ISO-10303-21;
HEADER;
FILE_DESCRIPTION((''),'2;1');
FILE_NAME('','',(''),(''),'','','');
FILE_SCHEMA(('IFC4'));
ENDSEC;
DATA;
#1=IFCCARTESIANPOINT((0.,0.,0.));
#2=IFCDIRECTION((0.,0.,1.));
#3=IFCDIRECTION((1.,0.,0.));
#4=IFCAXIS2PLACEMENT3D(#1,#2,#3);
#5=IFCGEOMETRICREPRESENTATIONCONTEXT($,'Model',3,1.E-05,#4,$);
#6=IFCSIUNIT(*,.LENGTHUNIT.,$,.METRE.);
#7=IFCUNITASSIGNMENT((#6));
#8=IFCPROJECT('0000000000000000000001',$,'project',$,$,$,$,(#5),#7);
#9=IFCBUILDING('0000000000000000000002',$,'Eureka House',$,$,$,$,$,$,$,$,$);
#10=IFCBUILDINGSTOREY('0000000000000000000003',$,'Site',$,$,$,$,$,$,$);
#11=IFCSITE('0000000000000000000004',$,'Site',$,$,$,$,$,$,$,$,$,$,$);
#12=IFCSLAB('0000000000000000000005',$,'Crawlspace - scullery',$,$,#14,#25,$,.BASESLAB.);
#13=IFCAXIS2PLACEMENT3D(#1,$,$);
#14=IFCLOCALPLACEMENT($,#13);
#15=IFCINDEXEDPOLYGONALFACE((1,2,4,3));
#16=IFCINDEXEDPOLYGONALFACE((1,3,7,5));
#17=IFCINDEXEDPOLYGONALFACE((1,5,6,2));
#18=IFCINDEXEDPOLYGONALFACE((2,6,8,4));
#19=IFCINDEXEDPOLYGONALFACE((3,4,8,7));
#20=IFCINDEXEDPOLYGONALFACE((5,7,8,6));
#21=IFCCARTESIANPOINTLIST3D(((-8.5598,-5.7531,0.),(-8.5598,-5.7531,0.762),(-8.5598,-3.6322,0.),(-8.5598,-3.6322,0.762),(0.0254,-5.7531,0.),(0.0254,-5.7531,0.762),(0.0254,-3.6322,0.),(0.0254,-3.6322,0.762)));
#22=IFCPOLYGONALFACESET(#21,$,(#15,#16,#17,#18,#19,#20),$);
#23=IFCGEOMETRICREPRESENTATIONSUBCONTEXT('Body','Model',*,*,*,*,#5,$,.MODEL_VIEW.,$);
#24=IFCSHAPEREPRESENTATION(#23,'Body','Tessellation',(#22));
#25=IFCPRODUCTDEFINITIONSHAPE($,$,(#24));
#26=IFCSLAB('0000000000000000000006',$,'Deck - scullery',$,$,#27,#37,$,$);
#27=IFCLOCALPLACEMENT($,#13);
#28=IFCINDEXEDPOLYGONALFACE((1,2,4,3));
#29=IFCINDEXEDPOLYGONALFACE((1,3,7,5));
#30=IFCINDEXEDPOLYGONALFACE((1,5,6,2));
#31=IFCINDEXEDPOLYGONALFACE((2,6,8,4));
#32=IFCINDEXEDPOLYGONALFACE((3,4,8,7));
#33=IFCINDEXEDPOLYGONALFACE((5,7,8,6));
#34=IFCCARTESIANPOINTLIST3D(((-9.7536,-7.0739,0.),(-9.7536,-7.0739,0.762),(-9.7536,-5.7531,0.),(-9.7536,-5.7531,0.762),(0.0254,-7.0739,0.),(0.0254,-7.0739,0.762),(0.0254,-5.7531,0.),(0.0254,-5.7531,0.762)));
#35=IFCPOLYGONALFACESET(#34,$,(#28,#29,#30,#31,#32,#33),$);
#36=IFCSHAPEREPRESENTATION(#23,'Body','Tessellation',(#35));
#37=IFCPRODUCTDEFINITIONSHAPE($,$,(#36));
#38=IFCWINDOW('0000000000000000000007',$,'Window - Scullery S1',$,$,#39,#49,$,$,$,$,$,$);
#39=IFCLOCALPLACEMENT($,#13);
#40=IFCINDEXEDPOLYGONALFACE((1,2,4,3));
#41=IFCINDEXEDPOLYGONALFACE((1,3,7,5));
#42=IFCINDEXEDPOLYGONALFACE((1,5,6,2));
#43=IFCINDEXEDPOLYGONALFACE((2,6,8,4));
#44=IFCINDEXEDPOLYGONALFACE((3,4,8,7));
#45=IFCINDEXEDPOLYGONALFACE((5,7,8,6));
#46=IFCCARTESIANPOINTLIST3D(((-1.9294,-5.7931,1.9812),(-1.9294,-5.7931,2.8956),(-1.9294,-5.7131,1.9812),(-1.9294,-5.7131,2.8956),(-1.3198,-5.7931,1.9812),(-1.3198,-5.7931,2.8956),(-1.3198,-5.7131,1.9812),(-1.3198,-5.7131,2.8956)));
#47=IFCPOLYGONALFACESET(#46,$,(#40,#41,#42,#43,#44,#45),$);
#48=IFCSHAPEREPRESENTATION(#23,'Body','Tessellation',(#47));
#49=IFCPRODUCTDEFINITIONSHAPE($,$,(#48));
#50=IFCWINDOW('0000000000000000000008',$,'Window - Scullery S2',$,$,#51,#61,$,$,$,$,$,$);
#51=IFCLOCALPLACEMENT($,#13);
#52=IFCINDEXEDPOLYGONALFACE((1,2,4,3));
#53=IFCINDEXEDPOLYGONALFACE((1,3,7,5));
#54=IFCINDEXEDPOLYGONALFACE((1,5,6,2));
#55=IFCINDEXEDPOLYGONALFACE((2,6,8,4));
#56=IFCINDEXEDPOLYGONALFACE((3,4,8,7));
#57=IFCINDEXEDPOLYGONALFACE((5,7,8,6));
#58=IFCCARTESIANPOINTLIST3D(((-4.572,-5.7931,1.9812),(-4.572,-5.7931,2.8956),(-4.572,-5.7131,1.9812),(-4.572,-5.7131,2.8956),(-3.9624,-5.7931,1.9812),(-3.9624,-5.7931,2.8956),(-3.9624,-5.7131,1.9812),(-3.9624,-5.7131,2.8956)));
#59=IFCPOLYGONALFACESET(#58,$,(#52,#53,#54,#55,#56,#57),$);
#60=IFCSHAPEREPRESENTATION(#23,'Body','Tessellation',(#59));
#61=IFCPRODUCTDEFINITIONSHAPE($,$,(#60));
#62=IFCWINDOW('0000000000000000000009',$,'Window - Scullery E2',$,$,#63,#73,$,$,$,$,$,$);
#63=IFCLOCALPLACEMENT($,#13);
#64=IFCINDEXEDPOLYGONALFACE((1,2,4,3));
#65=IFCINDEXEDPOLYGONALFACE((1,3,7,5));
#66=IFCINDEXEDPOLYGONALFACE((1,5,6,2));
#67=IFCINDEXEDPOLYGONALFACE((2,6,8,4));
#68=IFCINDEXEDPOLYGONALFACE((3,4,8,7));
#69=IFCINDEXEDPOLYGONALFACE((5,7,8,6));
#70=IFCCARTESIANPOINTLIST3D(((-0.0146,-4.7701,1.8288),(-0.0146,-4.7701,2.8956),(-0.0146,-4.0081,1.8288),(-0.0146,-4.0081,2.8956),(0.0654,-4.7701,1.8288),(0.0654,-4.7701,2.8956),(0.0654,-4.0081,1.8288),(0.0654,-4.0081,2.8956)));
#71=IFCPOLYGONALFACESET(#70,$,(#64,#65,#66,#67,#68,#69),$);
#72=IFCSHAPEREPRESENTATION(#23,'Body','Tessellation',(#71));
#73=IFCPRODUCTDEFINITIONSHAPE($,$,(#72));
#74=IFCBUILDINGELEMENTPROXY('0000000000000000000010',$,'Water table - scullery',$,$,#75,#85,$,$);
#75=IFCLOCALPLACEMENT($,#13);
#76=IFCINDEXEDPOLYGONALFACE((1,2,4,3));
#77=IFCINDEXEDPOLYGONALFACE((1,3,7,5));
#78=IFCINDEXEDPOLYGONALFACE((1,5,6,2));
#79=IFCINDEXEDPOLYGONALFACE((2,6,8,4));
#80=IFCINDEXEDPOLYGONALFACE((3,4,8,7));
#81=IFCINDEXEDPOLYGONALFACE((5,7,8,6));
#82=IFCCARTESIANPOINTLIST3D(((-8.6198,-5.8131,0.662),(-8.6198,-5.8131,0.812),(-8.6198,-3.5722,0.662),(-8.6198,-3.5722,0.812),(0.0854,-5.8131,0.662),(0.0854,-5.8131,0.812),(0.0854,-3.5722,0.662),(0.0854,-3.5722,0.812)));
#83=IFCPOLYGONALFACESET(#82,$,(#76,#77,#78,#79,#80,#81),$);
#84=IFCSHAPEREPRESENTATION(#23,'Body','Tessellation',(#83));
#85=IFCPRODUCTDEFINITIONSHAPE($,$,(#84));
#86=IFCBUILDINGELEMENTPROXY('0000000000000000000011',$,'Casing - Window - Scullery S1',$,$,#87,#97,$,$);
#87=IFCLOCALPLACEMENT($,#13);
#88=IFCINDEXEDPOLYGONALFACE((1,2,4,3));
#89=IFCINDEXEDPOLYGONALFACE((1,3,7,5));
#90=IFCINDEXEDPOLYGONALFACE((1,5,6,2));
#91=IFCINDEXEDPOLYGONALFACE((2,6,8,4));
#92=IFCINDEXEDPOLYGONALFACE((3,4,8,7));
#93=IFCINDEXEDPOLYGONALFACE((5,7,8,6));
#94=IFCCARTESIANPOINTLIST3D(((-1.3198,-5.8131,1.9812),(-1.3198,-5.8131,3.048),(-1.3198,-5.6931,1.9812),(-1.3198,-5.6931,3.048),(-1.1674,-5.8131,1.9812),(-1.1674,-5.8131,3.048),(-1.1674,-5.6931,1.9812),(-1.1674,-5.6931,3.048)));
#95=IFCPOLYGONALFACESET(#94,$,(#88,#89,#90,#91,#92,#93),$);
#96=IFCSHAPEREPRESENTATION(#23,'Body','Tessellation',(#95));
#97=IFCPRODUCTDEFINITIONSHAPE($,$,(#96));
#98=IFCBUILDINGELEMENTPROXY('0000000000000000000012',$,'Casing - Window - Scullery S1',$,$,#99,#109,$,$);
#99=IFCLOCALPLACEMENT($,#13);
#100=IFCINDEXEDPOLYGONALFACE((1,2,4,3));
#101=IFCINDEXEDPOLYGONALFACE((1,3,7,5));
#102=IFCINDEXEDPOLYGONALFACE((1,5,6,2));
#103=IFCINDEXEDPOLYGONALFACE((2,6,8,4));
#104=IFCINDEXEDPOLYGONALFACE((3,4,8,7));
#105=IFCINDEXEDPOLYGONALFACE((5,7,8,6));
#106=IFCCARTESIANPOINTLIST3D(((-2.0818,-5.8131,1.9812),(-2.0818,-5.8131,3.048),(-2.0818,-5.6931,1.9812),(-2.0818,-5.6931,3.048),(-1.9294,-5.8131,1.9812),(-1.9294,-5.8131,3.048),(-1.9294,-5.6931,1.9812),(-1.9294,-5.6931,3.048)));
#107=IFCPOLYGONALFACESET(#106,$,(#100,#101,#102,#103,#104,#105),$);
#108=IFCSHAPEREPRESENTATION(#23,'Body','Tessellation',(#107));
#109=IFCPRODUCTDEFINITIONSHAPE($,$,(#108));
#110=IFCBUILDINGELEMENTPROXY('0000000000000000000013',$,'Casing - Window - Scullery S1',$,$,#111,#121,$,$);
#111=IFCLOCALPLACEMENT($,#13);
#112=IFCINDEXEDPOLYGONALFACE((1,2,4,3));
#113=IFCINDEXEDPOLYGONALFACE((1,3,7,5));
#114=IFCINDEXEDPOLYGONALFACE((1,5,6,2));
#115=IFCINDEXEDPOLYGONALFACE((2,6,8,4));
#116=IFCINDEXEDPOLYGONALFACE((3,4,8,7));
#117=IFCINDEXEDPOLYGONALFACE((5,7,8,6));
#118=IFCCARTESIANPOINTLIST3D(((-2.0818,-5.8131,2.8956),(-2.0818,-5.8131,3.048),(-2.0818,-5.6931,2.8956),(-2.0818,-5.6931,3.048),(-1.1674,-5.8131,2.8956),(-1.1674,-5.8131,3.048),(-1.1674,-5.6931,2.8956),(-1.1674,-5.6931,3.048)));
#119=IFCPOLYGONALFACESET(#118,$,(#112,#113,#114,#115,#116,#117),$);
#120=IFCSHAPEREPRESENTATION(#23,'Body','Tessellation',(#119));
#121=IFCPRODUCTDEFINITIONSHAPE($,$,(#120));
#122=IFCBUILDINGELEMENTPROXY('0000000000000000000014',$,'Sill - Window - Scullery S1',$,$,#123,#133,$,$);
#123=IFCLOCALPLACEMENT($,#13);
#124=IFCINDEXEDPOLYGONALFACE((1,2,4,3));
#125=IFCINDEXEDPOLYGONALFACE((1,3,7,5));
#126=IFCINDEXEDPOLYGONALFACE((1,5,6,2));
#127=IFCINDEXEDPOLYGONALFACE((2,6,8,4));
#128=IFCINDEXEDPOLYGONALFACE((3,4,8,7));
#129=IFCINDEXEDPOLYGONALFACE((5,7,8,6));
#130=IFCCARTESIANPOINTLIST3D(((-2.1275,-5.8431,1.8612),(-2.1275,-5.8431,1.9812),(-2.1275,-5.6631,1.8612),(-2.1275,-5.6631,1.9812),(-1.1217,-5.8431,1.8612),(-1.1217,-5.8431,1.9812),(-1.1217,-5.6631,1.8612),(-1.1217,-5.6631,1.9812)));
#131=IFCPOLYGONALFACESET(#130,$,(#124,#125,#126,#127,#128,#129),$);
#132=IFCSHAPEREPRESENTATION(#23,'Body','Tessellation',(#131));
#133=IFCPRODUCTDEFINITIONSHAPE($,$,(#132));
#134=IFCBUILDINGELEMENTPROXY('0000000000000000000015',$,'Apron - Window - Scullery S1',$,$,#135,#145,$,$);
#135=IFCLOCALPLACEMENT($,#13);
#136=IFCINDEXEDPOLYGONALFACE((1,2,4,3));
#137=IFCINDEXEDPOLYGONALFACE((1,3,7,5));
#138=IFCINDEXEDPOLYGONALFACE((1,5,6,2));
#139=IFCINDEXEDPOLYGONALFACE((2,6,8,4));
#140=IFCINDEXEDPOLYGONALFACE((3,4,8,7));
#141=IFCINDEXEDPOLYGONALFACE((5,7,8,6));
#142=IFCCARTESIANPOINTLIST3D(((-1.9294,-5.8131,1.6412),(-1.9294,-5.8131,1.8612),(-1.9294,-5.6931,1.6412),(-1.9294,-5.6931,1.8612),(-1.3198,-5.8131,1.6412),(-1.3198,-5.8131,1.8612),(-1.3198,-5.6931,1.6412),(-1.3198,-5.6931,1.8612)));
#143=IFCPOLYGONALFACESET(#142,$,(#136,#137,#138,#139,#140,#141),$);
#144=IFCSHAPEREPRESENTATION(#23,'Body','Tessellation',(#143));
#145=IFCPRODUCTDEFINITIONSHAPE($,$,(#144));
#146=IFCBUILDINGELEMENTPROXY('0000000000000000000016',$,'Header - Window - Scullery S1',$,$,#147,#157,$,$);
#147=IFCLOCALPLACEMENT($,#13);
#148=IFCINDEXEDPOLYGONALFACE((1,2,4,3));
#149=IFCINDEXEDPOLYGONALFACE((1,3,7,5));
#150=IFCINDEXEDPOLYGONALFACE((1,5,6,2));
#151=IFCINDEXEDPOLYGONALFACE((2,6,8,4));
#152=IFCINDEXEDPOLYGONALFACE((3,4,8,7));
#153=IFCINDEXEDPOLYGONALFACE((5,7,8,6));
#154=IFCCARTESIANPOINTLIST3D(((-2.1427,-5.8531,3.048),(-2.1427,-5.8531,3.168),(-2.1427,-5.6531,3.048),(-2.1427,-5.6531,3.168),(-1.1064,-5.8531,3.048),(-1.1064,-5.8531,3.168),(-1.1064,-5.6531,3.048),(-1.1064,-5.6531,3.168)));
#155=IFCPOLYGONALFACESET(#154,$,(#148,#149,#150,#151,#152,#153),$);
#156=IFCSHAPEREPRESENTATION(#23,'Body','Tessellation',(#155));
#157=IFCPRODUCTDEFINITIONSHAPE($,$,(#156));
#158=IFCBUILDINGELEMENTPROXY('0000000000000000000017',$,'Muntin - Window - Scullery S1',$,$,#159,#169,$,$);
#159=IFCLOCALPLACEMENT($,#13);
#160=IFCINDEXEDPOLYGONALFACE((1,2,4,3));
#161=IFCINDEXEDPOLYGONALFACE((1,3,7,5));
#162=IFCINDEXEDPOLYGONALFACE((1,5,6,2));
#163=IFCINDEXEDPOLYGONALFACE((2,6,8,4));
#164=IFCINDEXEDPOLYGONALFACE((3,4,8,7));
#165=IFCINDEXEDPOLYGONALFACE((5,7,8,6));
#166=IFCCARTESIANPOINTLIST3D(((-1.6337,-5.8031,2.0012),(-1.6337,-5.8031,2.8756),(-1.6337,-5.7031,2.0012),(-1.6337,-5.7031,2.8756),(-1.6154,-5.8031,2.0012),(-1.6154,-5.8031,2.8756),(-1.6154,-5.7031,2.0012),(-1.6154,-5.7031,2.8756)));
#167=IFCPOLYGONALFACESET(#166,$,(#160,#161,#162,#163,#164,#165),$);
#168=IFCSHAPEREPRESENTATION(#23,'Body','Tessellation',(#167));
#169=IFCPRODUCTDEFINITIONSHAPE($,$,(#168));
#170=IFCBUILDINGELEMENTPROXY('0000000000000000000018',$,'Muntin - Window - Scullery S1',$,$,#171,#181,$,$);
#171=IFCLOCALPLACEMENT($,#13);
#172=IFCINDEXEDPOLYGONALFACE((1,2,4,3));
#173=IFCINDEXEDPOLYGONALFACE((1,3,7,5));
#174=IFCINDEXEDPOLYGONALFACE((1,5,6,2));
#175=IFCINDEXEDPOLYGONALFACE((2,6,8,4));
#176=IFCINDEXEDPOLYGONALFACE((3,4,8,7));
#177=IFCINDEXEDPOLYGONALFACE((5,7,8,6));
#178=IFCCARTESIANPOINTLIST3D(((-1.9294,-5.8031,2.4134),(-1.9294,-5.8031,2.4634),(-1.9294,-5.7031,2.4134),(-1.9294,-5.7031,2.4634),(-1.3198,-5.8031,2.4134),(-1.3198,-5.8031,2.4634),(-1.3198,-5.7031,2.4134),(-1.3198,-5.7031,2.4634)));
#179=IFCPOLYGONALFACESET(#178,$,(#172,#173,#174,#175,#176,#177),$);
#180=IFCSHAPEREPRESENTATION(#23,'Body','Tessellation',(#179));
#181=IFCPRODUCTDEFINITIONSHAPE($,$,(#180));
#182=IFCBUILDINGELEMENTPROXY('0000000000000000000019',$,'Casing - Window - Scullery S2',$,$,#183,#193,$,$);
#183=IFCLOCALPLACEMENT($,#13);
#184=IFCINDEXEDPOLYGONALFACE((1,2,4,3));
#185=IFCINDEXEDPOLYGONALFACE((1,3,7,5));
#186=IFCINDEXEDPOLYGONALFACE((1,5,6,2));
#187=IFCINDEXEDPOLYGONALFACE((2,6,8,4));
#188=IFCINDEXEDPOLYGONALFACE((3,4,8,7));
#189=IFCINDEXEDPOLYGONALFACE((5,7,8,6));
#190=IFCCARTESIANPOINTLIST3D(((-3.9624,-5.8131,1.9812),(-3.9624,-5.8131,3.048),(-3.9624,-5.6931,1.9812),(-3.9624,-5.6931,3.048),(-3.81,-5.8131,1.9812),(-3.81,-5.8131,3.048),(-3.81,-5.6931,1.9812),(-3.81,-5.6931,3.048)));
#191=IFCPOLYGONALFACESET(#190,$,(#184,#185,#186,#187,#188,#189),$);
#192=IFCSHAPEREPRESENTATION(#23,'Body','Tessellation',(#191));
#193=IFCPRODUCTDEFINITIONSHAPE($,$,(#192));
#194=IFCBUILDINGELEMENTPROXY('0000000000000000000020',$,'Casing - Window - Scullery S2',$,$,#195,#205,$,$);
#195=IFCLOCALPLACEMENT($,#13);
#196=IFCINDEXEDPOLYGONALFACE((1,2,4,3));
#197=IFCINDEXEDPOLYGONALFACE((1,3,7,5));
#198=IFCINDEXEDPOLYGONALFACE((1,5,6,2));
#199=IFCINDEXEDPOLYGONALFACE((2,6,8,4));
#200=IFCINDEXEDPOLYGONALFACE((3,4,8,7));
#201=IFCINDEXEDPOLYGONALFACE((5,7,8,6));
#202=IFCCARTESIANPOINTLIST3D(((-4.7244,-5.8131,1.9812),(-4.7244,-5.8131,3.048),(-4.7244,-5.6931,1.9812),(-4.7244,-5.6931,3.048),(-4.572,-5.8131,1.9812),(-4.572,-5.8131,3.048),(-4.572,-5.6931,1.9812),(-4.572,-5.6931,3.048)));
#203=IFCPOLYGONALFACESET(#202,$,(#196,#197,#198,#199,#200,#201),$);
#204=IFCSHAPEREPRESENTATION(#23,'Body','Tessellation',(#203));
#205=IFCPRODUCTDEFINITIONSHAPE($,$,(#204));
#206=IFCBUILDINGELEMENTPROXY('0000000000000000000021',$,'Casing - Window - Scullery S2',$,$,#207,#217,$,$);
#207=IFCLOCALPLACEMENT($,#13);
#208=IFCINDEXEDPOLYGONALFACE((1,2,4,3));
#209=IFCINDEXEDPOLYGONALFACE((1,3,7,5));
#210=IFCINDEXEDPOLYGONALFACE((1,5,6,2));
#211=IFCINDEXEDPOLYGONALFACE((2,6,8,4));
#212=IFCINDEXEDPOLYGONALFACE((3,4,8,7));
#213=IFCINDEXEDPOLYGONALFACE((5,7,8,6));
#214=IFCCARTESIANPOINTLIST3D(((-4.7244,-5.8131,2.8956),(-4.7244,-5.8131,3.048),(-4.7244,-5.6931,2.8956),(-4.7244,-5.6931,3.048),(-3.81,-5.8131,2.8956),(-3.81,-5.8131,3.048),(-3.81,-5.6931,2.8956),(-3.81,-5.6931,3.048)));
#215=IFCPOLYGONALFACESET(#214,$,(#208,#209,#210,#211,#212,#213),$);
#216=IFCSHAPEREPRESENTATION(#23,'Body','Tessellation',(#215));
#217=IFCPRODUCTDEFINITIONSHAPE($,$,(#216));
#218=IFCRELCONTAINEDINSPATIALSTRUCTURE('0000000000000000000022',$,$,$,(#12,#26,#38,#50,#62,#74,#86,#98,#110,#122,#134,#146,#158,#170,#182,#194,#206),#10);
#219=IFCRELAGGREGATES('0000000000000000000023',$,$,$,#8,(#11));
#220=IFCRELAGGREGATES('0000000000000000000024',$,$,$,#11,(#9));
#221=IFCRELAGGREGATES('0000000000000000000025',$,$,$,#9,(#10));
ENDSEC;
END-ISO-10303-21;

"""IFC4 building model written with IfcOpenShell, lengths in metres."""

from ifc_helpers import new_model, si_unit, frame, origin, origin_with_axes, origin_2d, place, context, subcontext, project, spatial, rectangle, extrude, element, save


model = new_model("IFC4")

# Units and contexts
model_context = context("Model", 3, precision=1e-05, world=origin_with_axes())
body_context = subcontext(model_context, "Body", "Model", "MODEL_VIEW")
ifc_project = project(units=[si_unit("LENGTHUNIT", "METRE")], contexts=[model_context])

# Site, building, storey
site = spatial("IfcSite", under=ifc_project, Name="Site")
building = spatial("IfcBuilding", under=site, Name="Eureka House")
storey = spatial("IfcBuildingStorey", under=building, Name="Site")

# Slabs
slab_1_placement = place(None, frame((-4.2672, -4.6927, 0.0), z_axis=(0.0, 0.0, 1.0), x_axis=(1.0, 0.0, 0.0)))
element("IfcSlab", 1, at=slab_1_placement, inside=storey, Name="Crawlspace - scullery", PredefinedType="BASESLAB", context=body_context, shape_type="SweptSolid", body=[
    extrude(rectangle(XDim=8.5852, YDim=2.1209, at=origin_2d()), origin(), (0.0, 0.0, 1.0), 0.762),
])
slab_2_placement = place(None, frame((-4.8641, -6.4135, 0.0), z_axis=(0.0, 0.0, 1.0), x_axis=(1.0, 0.0, 0.0)))
element("IfcSlab", 2, at=slab_2_placement, inside=storey, Name="Deck - scullery", context=body_context, shape_type="SweptSolid", body=[
    extrude(rectangle(XDim=9.779, YDim=1.3208, at=origin_2d()), origin(), (0.0, 0.0, 1.0), 0.762),
])

# Windows
for number, where, z_axis, x_axis, name in (
    (3, (-1.6246, -5.7531, 1.9812), (0.0, 0.0, 1.0), (1.0, 0.0, 0.0), "Window - Scullery S1"),
    (4, (-4.2672, -5.7531, 1.9812), (0.0, 0.0, 1.0), (1.0, 0.0, 0.0), "Window - Scullery S2"),
):
    element("IfcWindow", number, at=place(None, frame(where, z_axis=z_axis, x_axis=x_axis)), inside=storey, Name=name, context=body_context, shape_type="SweptSolid", body=[
        extrude(rectangle(XDim=0.6096, YDim=0.08, at=origin_2d()), origin(), (0.0, 0.0, 1.0), 0.9144),
    ])
window_placement = place(None, frame((0.0254, -4.3891, 1.8288), z_axis=(0.0, 0.0, 1.0), x_axis=(1.0, 0.0, 0.0)))
element("IfcWindow", 5, at=window_placement, inside=storey, Name="Window - Scullery E2", context=body_context, shape_type="SweptSolid", body=[
    extrude(rectangle(XDim=0.08, YDim=0.762, at=origin_2d()), origin(), (0.0, 0.0, 1.0), 1.0668),
])

# Building element proxies
proxy_1_placement = place(None, frame((-4.2672, -4.6927, 0.662), z_axis=(0.0, 0.0, 1.0), x_axis=(1.0, 0.0, 0.0)))
element("IfcBuildingElementProxy", 6, at=proxy_1_placement, inside=storey, Name="Water table - scullery", context=body_context, shape_type="SweptSolid", body=[
    extrude(rectangle(XDim=8.7052, YDim=2.2409, at=origin_2d()), origin(), (0.0, 0.0, 1.0), 0.15),
])
for number, where, z_axis, x_axis, name in (
    (7, (-1.2436, -5.7531, 1.9812), (0.0, 0.0, 1.0), (1.0, 0.0, 0.0), "Casing - Window - Scullery S1"),
    (8, (-2.0056, -5.7531, 1.9812), (0.0, 0.0, 1.0), (1.0, 0.0, 0.0), "Casing - Window - Scullery S1"),
):
    element("IfcBuildingElementProxy", number, at=place(None, frame(where, z_axis=z_axis, x_axis=x_axis)), inside=storey, Name=name, context=body_context, shape_type="SweptSolid", body=[
        extrude(rectangle(XDim=0.1524, YDim=0.12, at=origin_2d()), origin(), (0.0, 0.0, 1.0), 1.0668),
    ])
proxy_2_placement = place(None, frame((-1.6246, -5.7531, 2.8956), z_axis=(0.0, 0.0, 1.0), x_axis=(1.0, 0.0, 0.0)))
element("IfcBuildingElementProxy", 9, at=proxy_2_placement, inside=storey, Name="Casing - Window - Scullery S1", context=body_context, shape_type="SweptSolid", body=[
    extrude(rectangle(XDim=0.9144, YDim=0.12, at=origin_2d()), origin(), (0.0, 0.0, 1.0), 0.1524),
])
proxy_3_placement = place(None, frame((-1.6246, -5.7531, 1.8612), z_axis=(0.0, 0.0, 1.0), x_axis=(1.0, 0.0, 0.0)))
element("IfcBuildingElementProxy", 10, at=proxy_3_placement, inside=storey, Name="Sill - Window - Scullery S1", context=body_context, shape_type="SweptSolid", body=[
    extrude(rectangle(XDim=1.0058, YDim=0.18, at=origin_2d()), origin(), (0.0, 0.0, 1.0), 0.12),
])
proxy_4_placement = place(None, frame((-1.6246, -5.7531, 1.6412), z_axis=(0.0, 0.0, 1.0), x_axis=(1.0, 0.0, 0.0)))
element("IfcBuildingElementProxy", 11, at=proxy_4_placement, inside=storey, Name="Apron - Window - Scullery S1", context=body_context, shape_type="SweptSolid", body=[
    extrude(rectangle(XDim=0.6096, YDim=0.12, at=origin_2d()), origin(), (0.0, 0.0, 1.0), 0.22),
])
proxy_5_placement = place(None, frame((-1.6246, -5.7531, 3.048), z_axis=(0.0, 0.0, 1.0), x_axis=(1.0, 0.0, 0.0)))
element("IfcBuildingElementProxy", 12, at=proxy_5_placement, inside=storey, Name="Header - Window - Scullery S1", context=body_context, shape_type="SweptSolid", body=[
    extrude(rectangle(XDim=1.0363, YDim=0.2, at=origin_2d()), origin(), (0.0, 0.0, 1.0), 0.12),
])
proxy_6_placement = place(None, frame((-1.6246, -5.7531, 2.0012), z_axis=(0.0, 0.0, 1.0), x_axis=(1.0, 0.0, 0.0)))
element("IfcBuildingElementProxy", 13, at=proxy_6_placement, inside=storey, Name="Muntin - Window - Scullery S1", context=body_context, shape_type="SweptSolid", body=[
    extrude(rectangle(XDim=0.0183, YDim=0.1, at=origin_2d()), origin(), (0.0, 0.0, 1.0), 0.8744),
])
proxy_7_placement = place(None, frame((-1.6246, -5.7531, 2.4134), z_axis=(0.0, 0.0, 1.0), x_axis=(1.0, 0.0, 0.0)))
element("IfcBuildingElementProxy", 14, at=proxy_7_placement, inside=storey, Name="Muntin - Window - Scullery S1", context=body_context, shape_type="SweptSolid", body=[
    extrude(rectangle(XDim=0.6096, YDim=0.1, at=origin_2d()), origin(), (0.0, 0.0, 1.0), 0.05),
])
for number, where, z_axis, x_axis, name in (
    (15, (-3.8862, -5.7531, 1.9812), (0.0, 0.0, 1.0), (1.0, 0.0, 0.0), "Casing - Window - Scullery S2"),
    (16, (-4.6482, -5.7531, 1.9812), (0.0, 0.0, 1.0), (1.0, 0.0, 0.0), "Casing - Window - Scullery S2"),
):
    element("IfcBuildingElementProxy", number, at=place(None, frame(where, z_axis=z_axis, x_axis=x_axis)), inside=storey, Name=name, context=body_context, shape_type="SweptSolid", body=[
        extrude(rectangle(XDim=0.1524, YDim=0.12, at=origin_2d()), origin(), (0.0, 0.0, 1.0), 1.0668),
    ])
proxy_8_placement = place(None, frame((-4.2672, -5.7531, 2.8956), z_axis=(0.0, 0.0, 1.0), x_axis=(1.0, 0.0, 0.0)))
element("IfcBuildingElementProxy", 17, at=proxy_8_placement, inside=storey, Name="Casing - Window - Scullery S2", context=body_context, shape_type="SweptSolid", body=[
    extrude(rectangle(XDim=0.9144, YDim=0.12, at=origin_2d()), origin(), (0.0, 0.0, 1.0), 0.1524),
])

save(model, "model.ifc")
